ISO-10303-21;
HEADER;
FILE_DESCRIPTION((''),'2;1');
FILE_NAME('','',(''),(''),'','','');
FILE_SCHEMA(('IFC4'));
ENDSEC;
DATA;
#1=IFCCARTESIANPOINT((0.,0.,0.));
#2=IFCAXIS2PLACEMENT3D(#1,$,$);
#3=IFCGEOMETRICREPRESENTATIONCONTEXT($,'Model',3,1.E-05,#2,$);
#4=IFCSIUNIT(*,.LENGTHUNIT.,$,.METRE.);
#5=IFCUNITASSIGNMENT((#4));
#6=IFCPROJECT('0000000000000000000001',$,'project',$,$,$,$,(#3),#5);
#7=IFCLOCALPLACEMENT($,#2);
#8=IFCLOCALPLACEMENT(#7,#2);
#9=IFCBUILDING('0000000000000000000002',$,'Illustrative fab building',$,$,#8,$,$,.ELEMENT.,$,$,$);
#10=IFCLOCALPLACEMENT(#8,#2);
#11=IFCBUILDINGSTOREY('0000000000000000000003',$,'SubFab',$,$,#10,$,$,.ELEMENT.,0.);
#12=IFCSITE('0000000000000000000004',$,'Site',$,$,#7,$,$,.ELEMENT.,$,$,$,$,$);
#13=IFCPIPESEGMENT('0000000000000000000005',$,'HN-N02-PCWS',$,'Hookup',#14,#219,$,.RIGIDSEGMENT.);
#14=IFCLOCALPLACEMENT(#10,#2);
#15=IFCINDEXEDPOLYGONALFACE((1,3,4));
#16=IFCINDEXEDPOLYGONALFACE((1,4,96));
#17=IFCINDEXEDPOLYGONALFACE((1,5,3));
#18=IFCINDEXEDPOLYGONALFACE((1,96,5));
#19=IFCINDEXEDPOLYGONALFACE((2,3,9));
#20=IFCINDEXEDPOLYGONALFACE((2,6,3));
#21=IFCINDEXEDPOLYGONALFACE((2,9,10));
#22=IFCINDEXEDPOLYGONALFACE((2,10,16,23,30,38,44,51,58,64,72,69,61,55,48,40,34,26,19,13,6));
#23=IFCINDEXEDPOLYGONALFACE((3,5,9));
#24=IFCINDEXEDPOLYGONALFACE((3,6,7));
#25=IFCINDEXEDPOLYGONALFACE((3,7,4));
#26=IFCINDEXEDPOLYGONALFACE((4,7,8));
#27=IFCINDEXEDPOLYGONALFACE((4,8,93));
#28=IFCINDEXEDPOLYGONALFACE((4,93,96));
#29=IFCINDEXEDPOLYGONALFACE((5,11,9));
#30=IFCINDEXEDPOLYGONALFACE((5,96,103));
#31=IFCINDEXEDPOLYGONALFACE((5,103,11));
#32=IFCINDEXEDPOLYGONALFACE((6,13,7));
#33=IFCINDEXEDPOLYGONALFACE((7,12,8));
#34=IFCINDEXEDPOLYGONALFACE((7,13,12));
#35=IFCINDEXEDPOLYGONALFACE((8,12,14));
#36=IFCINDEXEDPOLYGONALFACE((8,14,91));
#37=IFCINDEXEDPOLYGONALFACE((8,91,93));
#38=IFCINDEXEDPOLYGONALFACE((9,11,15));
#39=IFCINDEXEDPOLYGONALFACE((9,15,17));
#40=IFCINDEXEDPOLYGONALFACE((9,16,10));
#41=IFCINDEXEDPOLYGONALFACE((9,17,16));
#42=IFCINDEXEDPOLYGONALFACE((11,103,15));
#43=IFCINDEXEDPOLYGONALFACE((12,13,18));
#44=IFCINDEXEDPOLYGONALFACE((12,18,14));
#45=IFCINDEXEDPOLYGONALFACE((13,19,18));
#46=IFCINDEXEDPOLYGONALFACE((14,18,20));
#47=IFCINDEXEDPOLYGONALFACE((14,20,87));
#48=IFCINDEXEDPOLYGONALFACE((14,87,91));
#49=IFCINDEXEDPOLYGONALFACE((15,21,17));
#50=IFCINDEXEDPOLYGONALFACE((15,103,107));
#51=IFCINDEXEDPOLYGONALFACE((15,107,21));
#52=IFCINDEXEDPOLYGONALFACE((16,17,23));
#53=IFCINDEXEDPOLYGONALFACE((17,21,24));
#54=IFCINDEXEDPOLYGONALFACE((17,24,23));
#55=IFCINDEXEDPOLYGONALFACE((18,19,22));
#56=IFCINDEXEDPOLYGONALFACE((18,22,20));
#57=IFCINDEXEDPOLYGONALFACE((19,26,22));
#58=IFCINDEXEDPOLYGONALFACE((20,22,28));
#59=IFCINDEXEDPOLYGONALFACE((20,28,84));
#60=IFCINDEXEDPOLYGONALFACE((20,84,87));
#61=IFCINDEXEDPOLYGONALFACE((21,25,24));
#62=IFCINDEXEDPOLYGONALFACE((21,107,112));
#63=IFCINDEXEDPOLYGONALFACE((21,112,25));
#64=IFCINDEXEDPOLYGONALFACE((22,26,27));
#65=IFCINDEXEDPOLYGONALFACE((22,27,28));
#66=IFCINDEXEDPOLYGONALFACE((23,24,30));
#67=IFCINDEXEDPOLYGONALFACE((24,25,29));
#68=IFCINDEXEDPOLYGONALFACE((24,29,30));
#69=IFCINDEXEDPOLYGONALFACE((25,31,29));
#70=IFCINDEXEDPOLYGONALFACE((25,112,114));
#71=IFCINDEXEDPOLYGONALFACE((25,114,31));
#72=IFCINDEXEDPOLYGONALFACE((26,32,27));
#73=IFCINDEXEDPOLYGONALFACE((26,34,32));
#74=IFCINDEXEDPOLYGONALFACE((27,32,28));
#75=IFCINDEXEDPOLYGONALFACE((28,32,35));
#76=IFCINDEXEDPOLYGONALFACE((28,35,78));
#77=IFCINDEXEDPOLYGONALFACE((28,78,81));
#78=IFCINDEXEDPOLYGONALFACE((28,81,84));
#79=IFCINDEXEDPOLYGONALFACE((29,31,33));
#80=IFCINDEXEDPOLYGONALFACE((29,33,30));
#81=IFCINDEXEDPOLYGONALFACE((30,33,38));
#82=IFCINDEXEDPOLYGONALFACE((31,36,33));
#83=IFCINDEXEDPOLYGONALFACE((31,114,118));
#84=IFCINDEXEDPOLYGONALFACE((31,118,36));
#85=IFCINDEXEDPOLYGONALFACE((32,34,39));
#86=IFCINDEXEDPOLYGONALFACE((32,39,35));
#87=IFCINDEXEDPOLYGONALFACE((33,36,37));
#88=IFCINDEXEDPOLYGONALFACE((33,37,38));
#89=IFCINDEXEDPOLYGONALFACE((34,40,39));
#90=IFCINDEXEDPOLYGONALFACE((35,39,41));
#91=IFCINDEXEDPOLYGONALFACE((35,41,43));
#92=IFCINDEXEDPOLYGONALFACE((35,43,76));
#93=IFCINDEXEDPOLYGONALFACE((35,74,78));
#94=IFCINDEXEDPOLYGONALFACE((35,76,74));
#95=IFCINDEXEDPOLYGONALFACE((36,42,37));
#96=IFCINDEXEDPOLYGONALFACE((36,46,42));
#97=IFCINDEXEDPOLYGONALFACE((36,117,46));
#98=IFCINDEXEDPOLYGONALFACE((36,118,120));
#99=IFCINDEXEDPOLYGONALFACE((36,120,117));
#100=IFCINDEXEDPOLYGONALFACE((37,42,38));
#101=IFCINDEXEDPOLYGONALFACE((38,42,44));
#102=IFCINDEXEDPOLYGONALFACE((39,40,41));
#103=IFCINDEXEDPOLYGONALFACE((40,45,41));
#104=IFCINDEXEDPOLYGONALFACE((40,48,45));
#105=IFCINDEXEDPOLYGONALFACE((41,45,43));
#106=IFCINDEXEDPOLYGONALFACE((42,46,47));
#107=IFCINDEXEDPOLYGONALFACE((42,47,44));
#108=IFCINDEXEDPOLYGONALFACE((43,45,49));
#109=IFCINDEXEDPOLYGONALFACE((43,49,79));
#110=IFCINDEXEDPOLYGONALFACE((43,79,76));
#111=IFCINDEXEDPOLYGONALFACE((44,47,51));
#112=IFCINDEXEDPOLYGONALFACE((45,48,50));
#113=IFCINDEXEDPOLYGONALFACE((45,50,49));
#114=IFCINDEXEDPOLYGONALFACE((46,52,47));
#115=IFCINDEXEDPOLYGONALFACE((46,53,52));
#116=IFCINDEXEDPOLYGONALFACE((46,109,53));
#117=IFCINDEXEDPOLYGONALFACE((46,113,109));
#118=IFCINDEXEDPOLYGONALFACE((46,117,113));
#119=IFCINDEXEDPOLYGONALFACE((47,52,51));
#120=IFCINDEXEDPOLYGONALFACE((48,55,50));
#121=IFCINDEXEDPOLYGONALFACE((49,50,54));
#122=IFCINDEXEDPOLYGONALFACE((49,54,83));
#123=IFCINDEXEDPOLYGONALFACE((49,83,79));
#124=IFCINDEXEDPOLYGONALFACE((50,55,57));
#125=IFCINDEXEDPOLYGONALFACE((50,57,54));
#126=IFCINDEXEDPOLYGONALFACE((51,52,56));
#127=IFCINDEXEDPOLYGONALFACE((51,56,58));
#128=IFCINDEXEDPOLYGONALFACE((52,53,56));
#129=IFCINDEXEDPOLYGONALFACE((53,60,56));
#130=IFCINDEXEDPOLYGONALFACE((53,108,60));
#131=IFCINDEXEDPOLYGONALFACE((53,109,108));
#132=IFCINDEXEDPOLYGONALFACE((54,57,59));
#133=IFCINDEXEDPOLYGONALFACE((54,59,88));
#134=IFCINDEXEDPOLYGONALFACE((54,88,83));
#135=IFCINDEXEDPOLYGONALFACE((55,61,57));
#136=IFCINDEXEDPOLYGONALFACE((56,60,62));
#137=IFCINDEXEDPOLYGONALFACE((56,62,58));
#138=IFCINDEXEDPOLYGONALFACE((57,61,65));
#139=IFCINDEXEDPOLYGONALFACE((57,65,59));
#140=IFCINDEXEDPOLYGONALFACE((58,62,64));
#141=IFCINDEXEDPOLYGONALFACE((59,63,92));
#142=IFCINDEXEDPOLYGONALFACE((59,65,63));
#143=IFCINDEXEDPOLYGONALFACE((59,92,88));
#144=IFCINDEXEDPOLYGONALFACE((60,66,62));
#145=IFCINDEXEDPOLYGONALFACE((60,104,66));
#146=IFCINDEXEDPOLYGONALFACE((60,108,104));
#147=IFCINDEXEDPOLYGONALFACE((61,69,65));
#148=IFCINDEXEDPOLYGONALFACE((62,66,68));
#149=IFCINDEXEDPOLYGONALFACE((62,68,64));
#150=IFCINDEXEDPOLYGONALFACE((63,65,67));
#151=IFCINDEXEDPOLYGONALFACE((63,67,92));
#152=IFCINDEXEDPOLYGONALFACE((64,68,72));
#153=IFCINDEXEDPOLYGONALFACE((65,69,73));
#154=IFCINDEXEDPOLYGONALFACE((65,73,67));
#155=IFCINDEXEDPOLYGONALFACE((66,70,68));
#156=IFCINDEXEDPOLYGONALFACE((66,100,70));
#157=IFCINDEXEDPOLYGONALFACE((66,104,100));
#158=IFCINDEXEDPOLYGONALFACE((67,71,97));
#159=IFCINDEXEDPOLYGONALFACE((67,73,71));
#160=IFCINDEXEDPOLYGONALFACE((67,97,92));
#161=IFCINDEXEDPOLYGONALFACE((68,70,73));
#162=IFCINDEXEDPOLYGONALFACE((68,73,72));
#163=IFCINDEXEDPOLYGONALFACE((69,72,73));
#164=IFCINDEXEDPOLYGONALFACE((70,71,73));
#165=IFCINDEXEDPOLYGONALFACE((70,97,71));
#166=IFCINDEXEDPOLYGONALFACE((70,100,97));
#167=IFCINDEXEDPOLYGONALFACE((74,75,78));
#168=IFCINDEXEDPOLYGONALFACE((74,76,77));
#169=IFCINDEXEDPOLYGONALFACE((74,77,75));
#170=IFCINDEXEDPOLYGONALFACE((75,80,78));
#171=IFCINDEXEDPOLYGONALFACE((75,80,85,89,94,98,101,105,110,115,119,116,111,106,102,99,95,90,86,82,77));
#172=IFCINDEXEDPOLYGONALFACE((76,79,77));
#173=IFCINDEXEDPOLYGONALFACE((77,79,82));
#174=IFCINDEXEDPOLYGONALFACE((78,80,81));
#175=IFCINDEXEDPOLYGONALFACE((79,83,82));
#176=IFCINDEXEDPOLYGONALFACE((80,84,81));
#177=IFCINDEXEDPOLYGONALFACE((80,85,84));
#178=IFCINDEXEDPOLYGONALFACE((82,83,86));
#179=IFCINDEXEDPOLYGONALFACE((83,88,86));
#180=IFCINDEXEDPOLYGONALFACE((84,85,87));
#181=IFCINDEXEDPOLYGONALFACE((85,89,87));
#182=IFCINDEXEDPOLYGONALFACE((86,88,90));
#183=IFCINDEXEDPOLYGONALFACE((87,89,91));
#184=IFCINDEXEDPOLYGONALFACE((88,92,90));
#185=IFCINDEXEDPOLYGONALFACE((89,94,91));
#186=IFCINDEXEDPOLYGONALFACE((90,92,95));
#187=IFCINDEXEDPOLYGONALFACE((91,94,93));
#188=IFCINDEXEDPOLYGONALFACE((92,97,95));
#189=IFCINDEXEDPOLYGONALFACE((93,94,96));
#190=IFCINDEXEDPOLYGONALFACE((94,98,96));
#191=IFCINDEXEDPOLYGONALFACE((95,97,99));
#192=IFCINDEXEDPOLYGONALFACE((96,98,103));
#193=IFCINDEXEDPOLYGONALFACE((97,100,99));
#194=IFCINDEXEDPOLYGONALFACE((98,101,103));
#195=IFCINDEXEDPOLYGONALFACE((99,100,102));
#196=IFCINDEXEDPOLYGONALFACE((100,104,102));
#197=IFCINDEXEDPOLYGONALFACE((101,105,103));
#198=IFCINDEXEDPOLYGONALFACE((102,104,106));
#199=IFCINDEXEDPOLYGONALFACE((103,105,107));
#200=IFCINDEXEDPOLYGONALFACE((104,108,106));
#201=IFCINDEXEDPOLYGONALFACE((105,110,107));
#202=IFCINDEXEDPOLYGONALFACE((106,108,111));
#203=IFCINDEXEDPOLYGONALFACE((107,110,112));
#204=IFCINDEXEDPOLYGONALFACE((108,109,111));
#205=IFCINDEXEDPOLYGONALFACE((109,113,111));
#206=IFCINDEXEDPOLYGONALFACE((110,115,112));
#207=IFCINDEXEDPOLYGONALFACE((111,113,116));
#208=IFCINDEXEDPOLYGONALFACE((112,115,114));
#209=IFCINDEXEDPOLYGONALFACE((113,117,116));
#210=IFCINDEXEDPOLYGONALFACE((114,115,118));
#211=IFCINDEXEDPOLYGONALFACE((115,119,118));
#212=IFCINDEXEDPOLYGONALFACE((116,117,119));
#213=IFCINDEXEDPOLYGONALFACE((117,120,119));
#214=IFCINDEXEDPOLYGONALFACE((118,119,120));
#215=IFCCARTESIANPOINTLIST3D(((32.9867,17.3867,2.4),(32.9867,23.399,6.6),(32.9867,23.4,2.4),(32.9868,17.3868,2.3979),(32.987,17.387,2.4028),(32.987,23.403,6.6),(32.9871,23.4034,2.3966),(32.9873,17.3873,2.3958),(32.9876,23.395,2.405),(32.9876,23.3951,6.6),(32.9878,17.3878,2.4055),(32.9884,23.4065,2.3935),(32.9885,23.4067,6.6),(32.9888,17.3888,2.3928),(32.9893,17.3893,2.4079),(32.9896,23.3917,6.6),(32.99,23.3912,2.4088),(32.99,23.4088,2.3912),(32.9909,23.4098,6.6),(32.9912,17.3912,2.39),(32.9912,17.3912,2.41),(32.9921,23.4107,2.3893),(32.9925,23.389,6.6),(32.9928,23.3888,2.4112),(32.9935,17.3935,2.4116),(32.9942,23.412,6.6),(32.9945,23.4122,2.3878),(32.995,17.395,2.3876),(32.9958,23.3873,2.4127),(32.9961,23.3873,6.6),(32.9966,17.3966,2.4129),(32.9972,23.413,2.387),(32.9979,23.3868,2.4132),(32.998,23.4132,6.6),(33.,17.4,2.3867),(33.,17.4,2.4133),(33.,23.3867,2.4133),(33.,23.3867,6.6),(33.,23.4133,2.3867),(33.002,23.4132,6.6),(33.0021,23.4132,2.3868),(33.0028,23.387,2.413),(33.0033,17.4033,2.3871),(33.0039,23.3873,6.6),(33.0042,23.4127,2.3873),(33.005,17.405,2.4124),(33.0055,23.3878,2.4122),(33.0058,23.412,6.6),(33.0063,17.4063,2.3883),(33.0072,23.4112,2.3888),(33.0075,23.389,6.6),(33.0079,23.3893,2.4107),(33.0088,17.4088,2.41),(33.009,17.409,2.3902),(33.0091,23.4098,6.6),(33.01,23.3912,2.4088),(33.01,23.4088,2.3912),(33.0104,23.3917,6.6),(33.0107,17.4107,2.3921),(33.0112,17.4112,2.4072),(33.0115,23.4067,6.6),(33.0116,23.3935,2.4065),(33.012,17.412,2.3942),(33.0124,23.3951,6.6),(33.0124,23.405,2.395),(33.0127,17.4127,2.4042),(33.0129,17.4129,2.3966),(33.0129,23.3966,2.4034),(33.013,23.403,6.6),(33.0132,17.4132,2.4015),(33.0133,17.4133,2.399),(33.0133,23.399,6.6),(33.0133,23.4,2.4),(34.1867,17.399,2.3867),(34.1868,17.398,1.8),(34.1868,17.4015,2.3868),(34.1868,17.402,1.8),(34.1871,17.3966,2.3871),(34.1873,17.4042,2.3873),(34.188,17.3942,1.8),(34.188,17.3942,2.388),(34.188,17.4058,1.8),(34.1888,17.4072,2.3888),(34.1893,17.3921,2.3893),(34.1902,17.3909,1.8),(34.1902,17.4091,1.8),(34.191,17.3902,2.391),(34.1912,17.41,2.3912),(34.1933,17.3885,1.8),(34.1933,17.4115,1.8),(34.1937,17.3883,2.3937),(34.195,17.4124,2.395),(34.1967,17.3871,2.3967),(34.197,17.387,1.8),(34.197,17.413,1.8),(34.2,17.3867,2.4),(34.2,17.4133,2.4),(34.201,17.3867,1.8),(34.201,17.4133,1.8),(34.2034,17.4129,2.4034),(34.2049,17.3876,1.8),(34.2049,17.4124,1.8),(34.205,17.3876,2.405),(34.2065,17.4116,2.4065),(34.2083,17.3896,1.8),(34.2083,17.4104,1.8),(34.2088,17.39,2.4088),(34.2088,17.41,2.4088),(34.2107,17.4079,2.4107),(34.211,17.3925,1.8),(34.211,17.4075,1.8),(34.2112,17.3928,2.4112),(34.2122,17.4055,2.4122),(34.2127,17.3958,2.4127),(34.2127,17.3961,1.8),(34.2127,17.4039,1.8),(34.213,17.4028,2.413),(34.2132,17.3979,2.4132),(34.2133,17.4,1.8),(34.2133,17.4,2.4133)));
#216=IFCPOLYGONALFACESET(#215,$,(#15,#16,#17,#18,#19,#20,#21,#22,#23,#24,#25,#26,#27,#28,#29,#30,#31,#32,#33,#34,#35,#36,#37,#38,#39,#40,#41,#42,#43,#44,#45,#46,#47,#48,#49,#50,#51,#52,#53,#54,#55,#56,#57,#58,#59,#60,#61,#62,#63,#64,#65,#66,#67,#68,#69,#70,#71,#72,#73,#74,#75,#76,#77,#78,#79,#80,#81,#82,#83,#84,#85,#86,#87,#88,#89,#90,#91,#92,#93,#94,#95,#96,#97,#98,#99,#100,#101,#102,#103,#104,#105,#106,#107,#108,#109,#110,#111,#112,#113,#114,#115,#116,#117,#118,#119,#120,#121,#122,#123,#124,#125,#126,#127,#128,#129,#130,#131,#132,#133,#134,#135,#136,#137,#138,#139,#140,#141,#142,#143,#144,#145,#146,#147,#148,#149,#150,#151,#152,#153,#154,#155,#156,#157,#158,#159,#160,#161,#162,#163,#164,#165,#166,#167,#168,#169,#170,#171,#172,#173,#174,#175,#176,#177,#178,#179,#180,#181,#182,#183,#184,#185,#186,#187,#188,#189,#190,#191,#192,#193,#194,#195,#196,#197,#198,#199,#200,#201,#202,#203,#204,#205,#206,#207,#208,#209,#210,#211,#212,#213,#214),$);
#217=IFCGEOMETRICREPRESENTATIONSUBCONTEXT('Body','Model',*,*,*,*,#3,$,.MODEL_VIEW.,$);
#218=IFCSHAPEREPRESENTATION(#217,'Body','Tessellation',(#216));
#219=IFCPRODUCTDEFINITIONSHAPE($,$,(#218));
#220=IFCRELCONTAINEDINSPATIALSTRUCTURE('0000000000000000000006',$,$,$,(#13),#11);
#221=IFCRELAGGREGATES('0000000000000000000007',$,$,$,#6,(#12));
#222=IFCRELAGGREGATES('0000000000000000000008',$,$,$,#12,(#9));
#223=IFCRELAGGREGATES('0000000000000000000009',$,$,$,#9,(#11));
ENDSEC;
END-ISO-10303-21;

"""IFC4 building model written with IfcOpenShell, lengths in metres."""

from ifc_helpers import new_model, entity, si_unit, origin, place, context, subcontext, project, spatial, element, save


model = new_model("IFC4")

# Units and contexts
model_context = context("Model", 3, precision=1e-05, world=origin())
body_context = subcontext(model_context, "Body", "Model", "MODEL_VIEW")
ifc_project = project(units=[si_unit("LENGTHUNIT", "METRE")], contexts=[model_context])

# Site, building, storey
site_placement = place(None, origin())
site = spatial("IfcSite", under=ifc_project, at=site_placement, Name="Site", CompositionType="ELEMENT")
building_placement = place(site_placement, origin())
building = spatial("IfcBuilding", under=site, at=building_placement, Name="Illustrative fab building", CompositionType="ELEMENT")
storey_placement = place(building_placement, origin())
storey = spatial("IfcBuildingStorey", under=building, at=storey_placement, Name="SubFab", CompositionType="ELEMENT", Elevation=0.0)

# Pipe segment
pipe_segment_1_placement = place(storey_placement, origin())
element("IfcPipeSegment", 1, at=pipe_segment_1_placement, inside=storey, Name="HN-N02-PCWS", ObjectType="Hookup", PredefinedType="RIGIDSEGMENT", context=body_context, shape_type="AdvancedSweptSolid", body=[
    entity("IfcSweptDiskSolid", entity("IfcPolyline", [entity("IfcCartesianPoint", [34.2, 17.4, 1.8]), entity("IfcCartesianPoint", [34.2, 17.4, 2.4]), entity("IfcCartesianPoint", [33.0, 17.4, 2.4]), entity("IfcCartesianPoint", [33.0, 23.4, 2.4]), entity("IfcCartesianPoint", [33.0, 23.4, 6.6])]), 0.0133),
])

save(model, "model.ifc")
